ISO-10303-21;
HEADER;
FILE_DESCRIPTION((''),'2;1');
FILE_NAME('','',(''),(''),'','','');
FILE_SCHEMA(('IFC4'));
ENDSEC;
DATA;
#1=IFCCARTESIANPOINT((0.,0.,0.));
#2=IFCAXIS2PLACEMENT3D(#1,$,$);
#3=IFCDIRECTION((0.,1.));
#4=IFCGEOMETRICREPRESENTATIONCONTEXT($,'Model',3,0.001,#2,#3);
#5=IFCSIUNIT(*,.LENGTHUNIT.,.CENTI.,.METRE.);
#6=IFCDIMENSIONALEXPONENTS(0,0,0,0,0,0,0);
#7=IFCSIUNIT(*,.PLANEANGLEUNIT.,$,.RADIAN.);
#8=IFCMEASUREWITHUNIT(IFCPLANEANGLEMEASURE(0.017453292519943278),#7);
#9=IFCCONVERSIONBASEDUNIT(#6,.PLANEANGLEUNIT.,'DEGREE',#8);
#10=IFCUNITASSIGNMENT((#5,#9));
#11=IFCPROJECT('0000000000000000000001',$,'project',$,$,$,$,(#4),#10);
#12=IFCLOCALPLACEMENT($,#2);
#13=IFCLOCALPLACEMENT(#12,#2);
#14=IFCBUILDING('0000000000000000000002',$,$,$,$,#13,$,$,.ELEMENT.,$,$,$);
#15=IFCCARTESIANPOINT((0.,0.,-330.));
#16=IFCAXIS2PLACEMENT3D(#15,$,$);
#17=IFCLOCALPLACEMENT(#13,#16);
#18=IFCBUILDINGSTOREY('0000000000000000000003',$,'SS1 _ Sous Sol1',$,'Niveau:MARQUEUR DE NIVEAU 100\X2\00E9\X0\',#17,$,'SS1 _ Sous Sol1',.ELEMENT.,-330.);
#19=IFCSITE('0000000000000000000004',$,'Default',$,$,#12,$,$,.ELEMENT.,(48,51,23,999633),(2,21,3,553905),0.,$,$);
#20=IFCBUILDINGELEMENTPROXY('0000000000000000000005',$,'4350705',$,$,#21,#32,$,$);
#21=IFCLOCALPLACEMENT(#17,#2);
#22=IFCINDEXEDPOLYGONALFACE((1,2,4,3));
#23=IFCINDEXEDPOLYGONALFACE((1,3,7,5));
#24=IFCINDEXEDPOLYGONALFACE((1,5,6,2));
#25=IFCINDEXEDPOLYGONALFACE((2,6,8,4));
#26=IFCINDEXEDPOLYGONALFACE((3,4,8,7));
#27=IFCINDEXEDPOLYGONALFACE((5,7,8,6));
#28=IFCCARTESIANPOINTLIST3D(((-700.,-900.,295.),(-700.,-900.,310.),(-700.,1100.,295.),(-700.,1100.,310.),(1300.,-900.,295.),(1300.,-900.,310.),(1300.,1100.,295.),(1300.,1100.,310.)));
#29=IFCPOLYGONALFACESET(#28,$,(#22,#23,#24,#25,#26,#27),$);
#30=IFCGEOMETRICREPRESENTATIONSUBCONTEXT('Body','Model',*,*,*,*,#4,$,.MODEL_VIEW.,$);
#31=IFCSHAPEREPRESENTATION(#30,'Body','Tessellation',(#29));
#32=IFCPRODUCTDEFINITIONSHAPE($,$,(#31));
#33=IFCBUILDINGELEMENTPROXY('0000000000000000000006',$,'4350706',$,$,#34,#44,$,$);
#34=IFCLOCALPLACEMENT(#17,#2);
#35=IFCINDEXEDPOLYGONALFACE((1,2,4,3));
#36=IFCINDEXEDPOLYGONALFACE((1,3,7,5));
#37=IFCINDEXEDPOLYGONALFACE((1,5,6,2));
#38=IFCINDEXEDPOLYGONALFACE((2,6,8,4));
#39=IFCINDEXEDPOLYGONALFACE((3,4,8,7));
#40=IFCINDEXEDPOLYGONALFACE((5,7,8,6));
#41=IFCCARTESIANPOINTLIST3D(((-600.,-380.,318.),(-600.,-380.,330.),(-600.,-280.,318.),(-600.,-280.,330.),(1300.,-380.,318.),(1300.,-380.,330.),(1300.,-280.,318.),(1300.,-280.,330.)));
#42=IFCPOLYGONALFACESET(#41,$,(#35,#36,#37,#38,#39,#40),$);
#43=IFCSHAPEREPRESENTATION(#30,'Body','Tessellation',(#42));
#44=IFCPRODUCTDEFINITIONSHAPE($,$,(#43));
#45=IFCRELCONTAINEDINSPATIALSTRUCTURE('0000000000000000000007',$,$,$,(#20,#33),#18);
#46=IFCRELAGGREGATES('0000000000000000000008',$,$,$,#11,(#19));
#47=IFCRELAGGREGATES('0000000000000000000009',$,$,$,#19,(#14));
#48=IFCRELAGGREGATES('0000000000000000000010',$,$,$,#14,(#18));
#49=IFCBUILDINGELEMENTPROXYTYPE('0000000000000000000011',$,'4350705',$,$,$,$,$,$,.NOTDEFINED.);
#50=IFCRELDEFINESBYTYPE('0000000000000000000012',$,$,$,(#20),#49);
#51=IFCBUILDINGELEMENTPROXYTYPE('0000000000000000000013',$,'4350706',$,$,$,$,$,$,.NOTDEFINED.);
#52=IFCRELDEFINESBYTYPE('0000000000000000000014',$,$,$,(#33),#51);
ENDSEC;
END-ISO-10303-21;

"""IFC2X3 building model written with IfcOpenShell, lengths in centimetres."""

from ifc_helpers import new_model, entity, si_unit, converted_unit, direction, frame, frame_2d, origin, origin_2d_with_axis, place, context, subcontext, project, spatial, rectangle, extrude, type_object, element, save


model = new_model("IFC2X3")

# Units and contexts
model_context = context("Model", 3, precision=0.001, world=origin(), true_north=direction((0.0, 1.0)))
body_context = subcontext(model_context, "Body", "Model", "MODEL_VIEW")
ifc_project = project(units=[si_unit("LENGTHUNIT", "METRE", prefix="CENTI"), converted_unit("PLANEANGLEUNIT", "DEGREE", entity("IfcPlaneAngleMeasure", 0.017453292519943278), si_unit("PLANEANGLEUNIT", "RADIAN"), dimensions=[0, 0, 0, 0, 0, 0, 0])], contexts=[model_context])

# Site, building, storey
site_placement = place(None, origin())
site = spatial("IfcSite", under=ifc_project, at=site_placement, Name="Default", CompositionType="ELEMENT", RefLatitude=(48, 51, 23, 999633), RefLongitude=(2, 21, 3, 553905), RefElevation=0.0)
building_placement = place(site_placement, origin())
building = spatial("IfcBuilding", under=site, at=building_placement, CompositionType="ELEMENT")
storey_placement = place(building_placement, frame((0.0, 0.0, -330.0)))
storey = spatial("IfcBuildingStorey", under=building, at=storey_placement, Name="SS1 _ Sous Sol1", ObjectType="Niveau:MARQUEUR DE NIVEAU 100é", LongName="SS1 _ Sous Sol1", CompositionType="ELEMENT", Elevation=-330.0)

# Building element proxies
building_element_proxy_type_1 = type_object("IfcBuildingElementProxyType", Name="4350705", PredefinedType="NOTDEFINED")
proxy_1_placement = place(storey_placement, origin())
element("IfcBuildingElementProxy", 1, at=proxy_1_placement, inside=storey, type_object=building_element_proxy_type_1, Name="4350705", context=body_context, shape_type="SweptSolid", body=[
    extrude(rectangle(XDim=2000.0, YDim=2000.0, at=frame_2d((0.0, 0.0), x_axis=(1.0, 0.0))), frame((300.0, 100.0, 295.0)), (0.0, 0.0, 1.0), 15.0),
])
building_element_proxy_type_2 = type_object("IfcBuildingElementProxyType", Name="4350706", PredefinedType="NOTDEFINED")
proxy_2_placement = place(storey_placement, origin())
element("IfcBuildingElementProxy", 2, at=proxy_2_placement, inside=storey, type_object=building_element_proxy_type_2, Name="4350706", context=body_context, shape_type="SweptSolid", body=[
    extrude(rectangle(XDim=1900.0, YDim=100.0, at=origin_2d_with_axis()), frame((350.0, -330.0, 318.0)), (0.0, 0.0, 1.0), 12.0),
])

save(model, "model.ifc")
